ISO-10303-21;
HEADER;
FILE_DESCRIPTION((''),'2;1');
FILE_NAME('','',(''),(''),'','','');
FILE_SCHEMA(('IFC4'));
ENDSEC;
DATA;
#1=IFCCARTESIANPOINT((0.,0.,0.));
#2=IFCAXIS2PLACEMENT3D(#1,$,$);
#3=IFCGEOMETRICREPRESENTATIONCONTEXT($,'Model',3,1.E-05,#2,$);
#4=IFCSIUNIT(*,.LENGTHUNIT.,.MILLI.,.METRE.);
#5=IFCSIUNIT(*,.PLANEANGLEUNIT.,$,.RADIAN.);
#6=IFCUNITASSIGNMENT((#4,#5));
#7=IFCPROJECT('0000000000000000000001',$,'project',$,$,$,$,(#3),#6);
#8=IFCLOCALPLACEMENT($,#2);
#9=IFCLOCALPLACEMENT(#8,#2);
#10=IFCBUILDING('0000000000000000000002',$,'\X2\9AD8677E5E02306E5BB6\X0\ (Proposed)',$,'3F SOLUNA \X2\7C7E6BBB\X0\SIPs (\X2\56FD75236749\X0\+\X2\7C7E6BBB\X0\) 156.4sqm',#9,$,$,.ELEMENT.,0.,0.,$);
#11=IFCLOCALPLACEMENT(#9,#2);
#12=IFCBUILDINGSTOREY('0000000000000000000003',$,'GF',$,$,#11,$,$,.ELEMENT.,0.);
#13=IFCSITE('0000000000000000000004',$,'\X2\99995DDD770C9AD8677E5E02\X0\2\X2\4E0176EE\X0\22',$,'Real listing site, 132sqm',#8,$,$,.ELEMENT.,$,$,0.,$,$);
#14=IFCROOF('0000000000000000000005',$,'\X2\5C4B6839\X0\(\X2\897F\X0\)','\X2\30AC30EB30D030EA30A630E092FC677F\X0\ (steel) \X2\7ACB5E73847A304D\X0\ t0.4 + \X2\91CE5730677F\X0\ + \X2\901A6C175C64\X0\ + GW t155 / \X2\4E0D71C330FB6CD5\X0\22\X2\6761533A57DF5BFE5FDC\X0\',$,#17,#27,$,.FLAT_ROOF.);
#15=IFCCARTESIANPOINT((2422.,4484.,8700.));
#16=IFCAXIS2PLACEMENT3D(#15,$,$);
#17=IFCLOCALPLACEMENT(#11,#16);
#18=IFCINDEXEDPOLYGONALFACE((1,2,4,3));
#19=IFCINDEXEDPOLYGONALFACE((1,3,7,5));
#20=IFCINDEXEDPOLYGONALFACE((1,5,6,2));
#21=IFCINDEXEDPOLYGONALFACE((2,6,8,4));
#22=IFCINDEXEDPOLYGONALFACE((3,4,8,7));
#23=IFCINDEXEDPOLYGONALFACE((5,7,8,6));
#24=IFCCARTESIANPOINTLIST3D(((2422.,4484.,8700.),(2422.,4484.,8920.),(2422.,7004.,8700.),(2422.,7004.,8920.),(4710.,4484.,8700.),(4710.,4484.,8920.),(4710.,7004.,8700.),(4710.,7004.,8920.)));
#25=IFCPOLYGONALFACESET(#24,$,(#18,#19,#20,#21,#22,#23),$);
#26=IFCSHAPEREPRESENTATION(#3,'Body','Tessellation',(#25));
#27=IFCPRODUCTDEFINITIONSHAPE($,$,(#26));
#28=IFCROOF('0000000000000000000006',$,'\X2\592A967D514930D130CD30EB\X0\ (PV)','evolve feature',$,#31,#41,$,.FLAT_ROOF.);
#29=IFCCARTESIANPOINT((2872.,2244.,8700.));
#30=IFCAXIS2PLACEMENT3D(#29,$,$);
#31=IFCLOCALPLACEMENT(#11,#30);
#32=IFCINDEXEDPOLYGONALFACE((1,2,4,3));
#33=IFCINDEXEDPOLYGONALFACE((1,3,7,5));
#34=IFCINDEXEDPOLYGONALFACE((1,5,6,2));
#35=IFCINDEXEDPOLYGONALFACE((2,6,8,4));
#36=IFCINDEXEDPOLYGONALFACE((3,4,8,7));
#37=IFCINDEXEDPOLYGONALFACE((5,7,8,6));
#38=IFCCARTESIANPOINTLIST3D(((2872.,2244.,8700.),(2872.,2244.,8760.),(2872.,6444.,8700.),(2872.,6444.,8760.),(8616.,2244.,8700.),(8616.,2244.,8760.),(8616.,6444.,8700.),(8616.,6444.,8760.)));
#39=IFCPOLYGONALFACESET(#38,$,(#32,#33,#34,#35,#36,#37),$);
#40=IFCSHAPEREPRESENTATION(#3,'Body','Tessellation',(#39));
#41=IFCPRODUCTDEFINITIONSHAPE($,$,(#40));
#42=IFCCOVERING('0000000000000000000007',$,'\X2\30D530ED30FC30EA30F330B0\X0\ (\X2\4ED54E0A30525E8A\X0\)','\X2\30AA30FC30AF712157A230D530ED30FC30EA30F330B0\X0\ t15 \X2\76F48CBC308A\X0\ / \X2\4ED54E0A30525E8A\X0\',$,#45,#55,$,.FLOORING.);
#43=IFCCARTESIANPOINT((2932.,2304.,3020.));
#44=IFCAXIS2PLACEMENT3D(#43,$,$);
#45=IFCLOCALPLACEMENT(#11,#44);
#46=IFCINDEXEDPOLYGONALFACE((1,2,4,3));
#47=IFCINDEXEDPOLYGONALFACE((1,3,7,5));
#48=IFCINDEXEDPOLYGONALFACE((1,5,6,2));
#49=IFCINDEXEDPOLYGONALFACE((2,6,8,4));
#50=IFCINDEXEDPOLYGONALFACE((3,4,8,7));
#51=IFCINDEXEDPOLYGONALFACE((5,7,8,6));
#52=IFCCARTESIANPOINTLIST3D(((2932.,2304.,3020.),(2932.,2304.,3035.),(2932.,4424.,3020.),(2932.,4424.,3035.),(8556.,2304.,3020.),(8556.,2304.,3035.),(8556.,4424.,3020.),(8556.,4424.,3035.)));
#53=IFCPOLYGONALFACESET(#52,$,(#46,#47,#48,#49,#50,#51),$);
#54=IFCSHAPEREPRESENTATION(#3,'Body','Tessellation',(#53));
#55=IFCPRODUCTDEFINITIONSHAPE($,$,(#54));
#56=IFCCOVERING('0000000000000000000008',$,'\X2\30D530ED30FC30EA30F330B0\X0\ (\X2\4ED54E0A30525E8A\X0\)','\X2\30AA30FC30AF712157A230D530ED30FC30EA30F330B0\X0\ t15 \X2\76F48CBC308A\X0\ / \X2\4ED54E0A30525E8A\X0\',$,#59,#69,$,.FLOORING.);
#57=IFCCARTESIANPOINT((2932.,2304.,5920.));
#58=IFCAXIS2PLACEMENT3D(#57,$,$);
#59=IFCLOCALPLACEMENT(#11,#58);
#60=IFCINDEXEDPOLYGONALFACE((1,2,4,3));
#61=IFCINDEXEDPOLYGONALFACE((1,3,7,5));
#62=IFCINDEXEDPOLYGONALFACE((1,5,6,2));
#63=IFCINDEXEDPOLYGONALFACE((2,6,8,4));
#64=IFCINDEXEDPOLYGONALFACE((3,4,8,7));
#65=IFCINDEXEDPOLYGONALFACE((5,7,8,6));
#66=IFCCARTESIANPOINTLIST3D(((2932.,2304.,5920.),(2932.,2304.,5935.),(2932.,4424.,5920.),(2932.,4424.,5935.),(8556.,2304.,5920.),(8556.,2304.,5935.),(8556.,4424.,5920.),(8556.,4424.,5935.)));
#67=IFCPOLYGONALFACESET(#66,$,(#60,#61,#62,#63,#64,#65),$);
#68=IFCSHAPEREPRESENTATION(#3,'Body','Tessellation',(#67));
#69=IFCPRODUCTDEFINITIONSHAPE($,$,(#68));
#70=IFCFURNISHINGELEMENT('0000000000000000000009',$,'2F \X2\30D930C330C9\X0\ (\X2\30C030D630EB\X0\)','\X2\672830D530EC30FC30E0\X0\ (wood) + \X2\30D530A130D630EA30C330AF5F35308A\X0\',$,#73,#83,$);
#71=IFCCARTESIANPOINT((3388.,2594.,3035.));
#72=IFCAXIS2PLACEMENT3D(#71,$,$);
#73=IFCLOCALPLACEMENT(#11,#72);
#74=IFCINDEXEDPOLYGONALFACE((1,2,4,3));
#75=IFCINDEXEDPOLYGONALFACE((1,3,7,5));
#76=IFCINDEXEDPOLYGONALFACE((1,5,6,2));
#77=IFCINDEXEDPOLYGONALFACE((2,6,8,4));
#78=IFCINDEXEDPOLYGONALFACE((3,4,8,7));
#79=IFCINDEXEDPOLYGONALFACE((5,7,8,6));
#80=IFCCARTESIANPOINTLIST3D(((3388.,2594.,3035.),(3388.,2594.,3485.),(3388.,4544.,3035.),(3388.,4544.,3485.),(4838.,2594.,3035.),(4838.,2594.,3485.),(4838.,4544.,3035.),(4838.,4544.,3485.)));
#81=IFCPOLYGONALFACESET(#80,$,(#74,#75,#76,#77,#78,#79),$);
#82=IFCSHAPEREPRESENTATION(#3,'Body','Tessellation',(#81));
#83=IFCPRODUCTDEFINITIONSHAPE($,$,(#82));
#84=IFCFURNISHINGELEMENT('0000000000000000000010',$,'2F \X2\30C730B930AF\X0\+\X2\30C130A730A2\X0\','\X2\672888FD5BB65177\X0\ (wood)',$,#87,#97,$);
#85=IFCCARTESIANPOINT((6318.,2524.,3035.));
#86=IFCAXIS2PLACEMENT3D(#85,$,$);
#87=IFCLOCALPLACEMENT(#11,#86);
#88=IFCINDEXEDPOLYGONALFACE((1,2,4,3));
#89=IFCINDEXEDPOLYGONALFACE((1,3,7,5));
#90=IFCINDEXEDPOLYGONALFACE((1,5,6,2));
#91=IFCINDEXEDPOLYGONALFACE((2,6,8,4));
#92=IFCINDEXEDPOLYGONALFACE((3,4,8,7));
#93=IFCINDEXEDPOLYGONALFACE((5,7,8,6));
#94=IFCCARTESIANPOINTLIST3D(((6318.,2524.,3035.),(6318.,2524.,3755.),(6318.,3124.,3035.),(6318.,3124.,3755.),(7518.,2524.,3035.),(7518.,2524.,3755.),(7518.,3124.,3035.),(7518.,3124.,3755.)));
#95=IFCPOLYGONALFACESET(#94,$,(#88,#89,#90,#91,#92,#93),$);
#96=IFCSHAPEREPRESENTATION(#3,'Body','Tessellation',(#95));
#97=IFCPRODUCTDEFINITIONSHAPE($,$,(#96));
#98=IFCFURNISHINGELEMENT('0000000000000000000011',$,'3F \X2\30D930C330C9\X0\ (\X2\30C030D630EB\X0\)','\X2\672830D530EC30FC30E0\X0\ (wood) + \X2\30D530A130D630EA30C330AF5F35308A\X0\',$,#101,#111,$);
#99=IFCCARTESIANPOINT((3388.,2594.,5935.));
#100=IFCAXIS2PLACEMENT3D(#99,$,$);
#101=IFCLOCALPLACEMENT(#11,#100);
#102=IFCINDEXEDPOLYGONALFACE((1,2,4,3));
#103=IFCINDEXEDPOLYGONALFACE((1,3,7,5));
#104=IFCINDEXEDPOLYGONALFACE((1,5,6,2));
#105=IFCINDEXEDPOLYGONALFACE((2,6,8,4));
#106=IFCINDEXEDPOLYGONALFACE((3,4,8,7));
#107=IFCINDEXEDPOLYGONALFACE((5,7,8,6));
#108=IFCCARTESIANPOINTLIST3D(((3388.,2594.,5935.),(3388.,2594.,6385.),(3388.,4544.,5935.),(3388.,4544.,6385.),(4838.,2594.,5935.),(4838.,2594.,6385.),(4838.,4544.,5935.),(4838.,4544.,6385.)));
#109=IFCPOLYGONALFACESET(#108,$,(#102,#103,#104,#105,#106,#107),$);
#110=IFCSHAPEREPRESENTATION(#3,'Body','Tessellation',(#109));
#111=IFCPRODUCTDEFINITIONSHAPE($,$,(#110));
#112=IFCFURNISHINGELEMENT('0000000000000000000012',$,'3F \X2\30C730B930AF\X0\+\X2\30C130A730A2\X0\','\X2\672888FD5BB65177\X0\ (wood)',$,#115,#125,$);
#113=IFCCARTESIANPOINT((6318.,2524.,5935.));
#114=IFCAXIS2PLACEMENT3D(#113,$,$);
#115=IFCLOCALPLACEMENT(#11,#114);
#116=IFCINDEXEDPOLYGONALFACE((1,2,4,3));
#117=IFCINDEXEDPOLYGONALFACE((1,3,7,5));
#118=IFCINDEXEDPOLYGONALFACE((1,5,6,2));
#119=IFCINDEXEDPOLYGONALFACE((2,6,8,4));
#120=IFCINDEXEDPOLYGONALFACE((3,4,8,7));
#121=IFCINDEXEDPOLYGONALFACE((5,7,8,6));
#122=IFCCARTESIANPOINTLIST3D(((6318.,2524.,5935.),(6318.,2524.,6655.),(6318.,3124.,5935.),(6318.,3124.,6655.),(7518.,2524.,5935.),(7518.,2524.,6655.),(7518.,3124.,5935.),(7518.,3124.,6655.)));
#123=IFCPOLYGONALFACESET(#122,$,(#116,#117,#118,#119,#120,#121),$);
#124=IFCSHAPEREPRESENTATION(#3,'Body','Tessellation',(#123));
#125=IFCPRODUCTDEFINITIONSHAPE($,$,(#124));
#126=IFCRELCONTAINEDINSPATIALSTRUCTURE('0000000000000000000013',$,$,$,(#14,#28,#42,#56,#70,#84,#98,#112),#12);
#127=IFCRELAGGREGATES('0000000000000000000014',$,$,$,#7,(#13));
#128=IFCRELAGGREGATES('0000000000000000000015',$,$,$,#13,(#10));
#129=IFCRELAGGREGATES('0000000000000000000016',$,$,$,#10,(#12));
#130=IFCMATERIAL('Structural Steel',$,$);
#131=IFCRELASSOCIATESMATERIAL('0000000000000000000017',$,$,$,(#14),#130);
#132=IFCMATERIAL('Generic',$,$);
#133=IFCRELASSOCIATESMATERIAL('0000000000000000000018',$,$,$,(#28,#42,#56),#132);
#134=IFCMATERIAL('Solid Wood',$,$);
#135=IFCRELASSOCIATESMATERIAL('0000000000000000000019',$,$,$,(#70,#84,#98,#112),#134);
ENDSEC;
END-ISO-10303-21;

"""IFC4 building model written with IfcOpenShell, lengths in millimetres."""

from ifc_helpers import new_model, si_unit, frame, frame_2d, origin, place, context, project, spatial, rectangle, extrude, material, element, save


model = new_model("IFC4")

# Units and contexts
model_context = context("Model", 3, precision=1e-05, world=origin())
ifc_project = project(units=[si_unit("LENGTHUNIT", "METRE", prefix="MILLI"), si_unit("PLANEANGLEUNIT", "RADIAN")], contexts=[model_context])

# Site, building, storey
site_placement = place(None, origin())
site = spatial("IfcSite", under=ifc_project, at=site_placement, Name="香川県高松市2丁目22", ObjectType="Real listing site, 132sqm", CompositionType="ELEMENT", RefElevation=0.0)
building_placement = place(site_placement, origin())
building = spatial("IfcBuilding", under=site, at=building_placement, Name="高松市の家 (Proposed)", ObjectType="3F SOLUNA 籾殻SIPs (国産杉+籾殻) 156.4sqm", CompositionType="ELEMENT", ElevationOfRefHeight=0.0, ElevationOfTerrain=0.0)
storey_placement = place(building_placement, origin())
storey = spatial("IfcBuildingStorey", under=building, at=storey_placement, Name="GF", CompositionType="ELEMENT", Elevation=0.0)

# Shared definitions
ifc_material_1 = material(Name="Solid Wood")

# Roofs
ifc_material_2 = material(Name="Structural Steel")
roof_1_placement = place(storey_placement, frame((2422.0, 4484.0, 8700.0)))
element("IfcRoof", 1, at=roof_1_placement, inside=storey, material=ifc_material_2, Name="屋根(西)", Description="ガルバリウム鋼板 (steel) 立平葺き t0.4 + 野地板 + 通気層 + GW t155 / 不燃・法22条区域対応", PredefinedType="FLAT_ROOF", context=model_context, shape_type="SweptSolid", body=[
    extrude(rectangle(XDim=2288.0, YDim=2520.0, at=frame_2d((1144.0, 1260.0))), frame((2422.0, 4484.0, 8700.0)), (0.0, 0.0, 1.0), 220.0),
])
ifc_material_3 = material(Name="Generic")
roof_2_placement = place(storey_placement, frame((2872.0, 2244.0, 8700.0)))
element("IfcRoof", 2, at=roof_2_placement, inside=storey, material=ifc_material_3, Name="太陽光パネル (PV)", Description="evolve feature", PredefinedType="FLAT_ROOF", context=model_context, shape_type="SweptSolid", body=[
    extrude(rectangle(XDim=5744.0, YDim=4200.0, at=frame_2d((2872.0, 2100.0))), frame((2872.0, 2244.0, 8700.0)), (0.0, 0.0, 1.0), 60.0),
])

# Coverings
covering_1_placement = place(storey_placement, frame((2932.0, 2304.0, 3020.0)))
element("IfcCovering", 3, at=covering_1_placement, inside=storey, material=ifc_material_3, Name="フローリング (仕上げ床)", Description="オーク無垢フローリング t15 直貼り / 仕上げ床", PredefinedType="FLOORING", context=model_context, shape_type="SweptSolid", body=[
    extrude(rectangle(XDim=5624.0, YDim=2120.0, at=frame_2d((2812.0, 1060.0))), frame((2932.0, 2304.0, 3020.0)), (0.0, 0.0, 1.0), 15.0),
])
covering_2_placement = place(storey_placement, frame((2932.0, 2304.0, 5920.0)))
element("IfcCovering", 4, at=covering_2_placement, inside=storey, material=ifc_material_3, Name="フローリング (仕上げ床)", Description="オーク無垢フローリング t15 直貼り / 仕上げ床", PredefinedType="FLOORING", context=model_context, shape_type="SweptSolid", body=[
    extrude(rectangle(XDim=5624.0, YDim=2120.0, at=frame_2d((2812.0, 1060.0))), frame((2932.0, 2304.0, 5920.0)), (0.0, 0.0, 1.0), 15.0),
])

# Furnishing elements
furnishing_1_placement = place(storey_placement, frame((3388.0, 2594.0, 3035.0)))
element("IfcFurnishingElement", 5, at=furnishing_1_placement, inside=storey, material=ifc_material_1, Name="2F ベッド (ダブル)", Description="木フレーム (wood) + ファブリック張り", context=model_context, shape_type="SweptSolid", body=[
    extrude(rectangle(XDim=1450.0, YDim=1950.0, at=frame_2d((725.0, 975.0))), frame((3388.0, 2594.0, 3035.0)), (0.0, 0.0, 1.0), 450.0),
])
furnishing_2_placement = place(storey_placement, frame((6318.0, 2524.0, 3035.0)))
element("IfcFurnishingElement", 6, at=furnishing_2_placement, inside=storey, material=ifc_material_1, Name="2F デスク+チェア", Description="木製家具 (wood)", context=model_context, shape_type="SweptSolid", body=[
    extrude(rectangle(XDim=1200.0, YDim=600.0, at=frame_2d((600.0, 300.0))), frame((6318.0, 2524.0, 3035.0)), (0.0, 0.0, 1.0), 720.0),
])
furnishing_3_placement = place(storey_placement, frame((3388.0, 2594.0, 5935.0)))
element("IfcFurnishingElement", 7, at=furnishing_3_placement, inside=storey, material=ifc_material_1, Name="3F ベッド (ダブル)", Description="木フレーム (wood) + ファブリック張り", context=model_context, shape_type="SweptSolid", body=[
    extrude(rectangle(XDim=1450.0, YDim=1950.0, at=frame_2d((725.0, 975.0))), frame((3388.0, 2594.0, 5935.0)), (0.0, 0.0, 1.0), 450.0),
])
furnishing_4_placement = place(storey_placement, frame((6318.0, 2524.0, 5935.0)))
element("IfcFurnishingElement", 8, at=furnishing_4_placement, inside=storey, material=ifc_material_1, Name="3F デスク+チェア", Description="木製家具 (wood)", context=model_context, shape_type="SweptSolid", body=[
    extrude(rectangle(XDim=1200.0, YDim=600.0, at=frame_2d((600.0, 300.0))), frame((6318.0, 2524.0, 5935.0)), (0.0, 0.0, 1.0), 720.0),
])

save(model, "model.ifc")
